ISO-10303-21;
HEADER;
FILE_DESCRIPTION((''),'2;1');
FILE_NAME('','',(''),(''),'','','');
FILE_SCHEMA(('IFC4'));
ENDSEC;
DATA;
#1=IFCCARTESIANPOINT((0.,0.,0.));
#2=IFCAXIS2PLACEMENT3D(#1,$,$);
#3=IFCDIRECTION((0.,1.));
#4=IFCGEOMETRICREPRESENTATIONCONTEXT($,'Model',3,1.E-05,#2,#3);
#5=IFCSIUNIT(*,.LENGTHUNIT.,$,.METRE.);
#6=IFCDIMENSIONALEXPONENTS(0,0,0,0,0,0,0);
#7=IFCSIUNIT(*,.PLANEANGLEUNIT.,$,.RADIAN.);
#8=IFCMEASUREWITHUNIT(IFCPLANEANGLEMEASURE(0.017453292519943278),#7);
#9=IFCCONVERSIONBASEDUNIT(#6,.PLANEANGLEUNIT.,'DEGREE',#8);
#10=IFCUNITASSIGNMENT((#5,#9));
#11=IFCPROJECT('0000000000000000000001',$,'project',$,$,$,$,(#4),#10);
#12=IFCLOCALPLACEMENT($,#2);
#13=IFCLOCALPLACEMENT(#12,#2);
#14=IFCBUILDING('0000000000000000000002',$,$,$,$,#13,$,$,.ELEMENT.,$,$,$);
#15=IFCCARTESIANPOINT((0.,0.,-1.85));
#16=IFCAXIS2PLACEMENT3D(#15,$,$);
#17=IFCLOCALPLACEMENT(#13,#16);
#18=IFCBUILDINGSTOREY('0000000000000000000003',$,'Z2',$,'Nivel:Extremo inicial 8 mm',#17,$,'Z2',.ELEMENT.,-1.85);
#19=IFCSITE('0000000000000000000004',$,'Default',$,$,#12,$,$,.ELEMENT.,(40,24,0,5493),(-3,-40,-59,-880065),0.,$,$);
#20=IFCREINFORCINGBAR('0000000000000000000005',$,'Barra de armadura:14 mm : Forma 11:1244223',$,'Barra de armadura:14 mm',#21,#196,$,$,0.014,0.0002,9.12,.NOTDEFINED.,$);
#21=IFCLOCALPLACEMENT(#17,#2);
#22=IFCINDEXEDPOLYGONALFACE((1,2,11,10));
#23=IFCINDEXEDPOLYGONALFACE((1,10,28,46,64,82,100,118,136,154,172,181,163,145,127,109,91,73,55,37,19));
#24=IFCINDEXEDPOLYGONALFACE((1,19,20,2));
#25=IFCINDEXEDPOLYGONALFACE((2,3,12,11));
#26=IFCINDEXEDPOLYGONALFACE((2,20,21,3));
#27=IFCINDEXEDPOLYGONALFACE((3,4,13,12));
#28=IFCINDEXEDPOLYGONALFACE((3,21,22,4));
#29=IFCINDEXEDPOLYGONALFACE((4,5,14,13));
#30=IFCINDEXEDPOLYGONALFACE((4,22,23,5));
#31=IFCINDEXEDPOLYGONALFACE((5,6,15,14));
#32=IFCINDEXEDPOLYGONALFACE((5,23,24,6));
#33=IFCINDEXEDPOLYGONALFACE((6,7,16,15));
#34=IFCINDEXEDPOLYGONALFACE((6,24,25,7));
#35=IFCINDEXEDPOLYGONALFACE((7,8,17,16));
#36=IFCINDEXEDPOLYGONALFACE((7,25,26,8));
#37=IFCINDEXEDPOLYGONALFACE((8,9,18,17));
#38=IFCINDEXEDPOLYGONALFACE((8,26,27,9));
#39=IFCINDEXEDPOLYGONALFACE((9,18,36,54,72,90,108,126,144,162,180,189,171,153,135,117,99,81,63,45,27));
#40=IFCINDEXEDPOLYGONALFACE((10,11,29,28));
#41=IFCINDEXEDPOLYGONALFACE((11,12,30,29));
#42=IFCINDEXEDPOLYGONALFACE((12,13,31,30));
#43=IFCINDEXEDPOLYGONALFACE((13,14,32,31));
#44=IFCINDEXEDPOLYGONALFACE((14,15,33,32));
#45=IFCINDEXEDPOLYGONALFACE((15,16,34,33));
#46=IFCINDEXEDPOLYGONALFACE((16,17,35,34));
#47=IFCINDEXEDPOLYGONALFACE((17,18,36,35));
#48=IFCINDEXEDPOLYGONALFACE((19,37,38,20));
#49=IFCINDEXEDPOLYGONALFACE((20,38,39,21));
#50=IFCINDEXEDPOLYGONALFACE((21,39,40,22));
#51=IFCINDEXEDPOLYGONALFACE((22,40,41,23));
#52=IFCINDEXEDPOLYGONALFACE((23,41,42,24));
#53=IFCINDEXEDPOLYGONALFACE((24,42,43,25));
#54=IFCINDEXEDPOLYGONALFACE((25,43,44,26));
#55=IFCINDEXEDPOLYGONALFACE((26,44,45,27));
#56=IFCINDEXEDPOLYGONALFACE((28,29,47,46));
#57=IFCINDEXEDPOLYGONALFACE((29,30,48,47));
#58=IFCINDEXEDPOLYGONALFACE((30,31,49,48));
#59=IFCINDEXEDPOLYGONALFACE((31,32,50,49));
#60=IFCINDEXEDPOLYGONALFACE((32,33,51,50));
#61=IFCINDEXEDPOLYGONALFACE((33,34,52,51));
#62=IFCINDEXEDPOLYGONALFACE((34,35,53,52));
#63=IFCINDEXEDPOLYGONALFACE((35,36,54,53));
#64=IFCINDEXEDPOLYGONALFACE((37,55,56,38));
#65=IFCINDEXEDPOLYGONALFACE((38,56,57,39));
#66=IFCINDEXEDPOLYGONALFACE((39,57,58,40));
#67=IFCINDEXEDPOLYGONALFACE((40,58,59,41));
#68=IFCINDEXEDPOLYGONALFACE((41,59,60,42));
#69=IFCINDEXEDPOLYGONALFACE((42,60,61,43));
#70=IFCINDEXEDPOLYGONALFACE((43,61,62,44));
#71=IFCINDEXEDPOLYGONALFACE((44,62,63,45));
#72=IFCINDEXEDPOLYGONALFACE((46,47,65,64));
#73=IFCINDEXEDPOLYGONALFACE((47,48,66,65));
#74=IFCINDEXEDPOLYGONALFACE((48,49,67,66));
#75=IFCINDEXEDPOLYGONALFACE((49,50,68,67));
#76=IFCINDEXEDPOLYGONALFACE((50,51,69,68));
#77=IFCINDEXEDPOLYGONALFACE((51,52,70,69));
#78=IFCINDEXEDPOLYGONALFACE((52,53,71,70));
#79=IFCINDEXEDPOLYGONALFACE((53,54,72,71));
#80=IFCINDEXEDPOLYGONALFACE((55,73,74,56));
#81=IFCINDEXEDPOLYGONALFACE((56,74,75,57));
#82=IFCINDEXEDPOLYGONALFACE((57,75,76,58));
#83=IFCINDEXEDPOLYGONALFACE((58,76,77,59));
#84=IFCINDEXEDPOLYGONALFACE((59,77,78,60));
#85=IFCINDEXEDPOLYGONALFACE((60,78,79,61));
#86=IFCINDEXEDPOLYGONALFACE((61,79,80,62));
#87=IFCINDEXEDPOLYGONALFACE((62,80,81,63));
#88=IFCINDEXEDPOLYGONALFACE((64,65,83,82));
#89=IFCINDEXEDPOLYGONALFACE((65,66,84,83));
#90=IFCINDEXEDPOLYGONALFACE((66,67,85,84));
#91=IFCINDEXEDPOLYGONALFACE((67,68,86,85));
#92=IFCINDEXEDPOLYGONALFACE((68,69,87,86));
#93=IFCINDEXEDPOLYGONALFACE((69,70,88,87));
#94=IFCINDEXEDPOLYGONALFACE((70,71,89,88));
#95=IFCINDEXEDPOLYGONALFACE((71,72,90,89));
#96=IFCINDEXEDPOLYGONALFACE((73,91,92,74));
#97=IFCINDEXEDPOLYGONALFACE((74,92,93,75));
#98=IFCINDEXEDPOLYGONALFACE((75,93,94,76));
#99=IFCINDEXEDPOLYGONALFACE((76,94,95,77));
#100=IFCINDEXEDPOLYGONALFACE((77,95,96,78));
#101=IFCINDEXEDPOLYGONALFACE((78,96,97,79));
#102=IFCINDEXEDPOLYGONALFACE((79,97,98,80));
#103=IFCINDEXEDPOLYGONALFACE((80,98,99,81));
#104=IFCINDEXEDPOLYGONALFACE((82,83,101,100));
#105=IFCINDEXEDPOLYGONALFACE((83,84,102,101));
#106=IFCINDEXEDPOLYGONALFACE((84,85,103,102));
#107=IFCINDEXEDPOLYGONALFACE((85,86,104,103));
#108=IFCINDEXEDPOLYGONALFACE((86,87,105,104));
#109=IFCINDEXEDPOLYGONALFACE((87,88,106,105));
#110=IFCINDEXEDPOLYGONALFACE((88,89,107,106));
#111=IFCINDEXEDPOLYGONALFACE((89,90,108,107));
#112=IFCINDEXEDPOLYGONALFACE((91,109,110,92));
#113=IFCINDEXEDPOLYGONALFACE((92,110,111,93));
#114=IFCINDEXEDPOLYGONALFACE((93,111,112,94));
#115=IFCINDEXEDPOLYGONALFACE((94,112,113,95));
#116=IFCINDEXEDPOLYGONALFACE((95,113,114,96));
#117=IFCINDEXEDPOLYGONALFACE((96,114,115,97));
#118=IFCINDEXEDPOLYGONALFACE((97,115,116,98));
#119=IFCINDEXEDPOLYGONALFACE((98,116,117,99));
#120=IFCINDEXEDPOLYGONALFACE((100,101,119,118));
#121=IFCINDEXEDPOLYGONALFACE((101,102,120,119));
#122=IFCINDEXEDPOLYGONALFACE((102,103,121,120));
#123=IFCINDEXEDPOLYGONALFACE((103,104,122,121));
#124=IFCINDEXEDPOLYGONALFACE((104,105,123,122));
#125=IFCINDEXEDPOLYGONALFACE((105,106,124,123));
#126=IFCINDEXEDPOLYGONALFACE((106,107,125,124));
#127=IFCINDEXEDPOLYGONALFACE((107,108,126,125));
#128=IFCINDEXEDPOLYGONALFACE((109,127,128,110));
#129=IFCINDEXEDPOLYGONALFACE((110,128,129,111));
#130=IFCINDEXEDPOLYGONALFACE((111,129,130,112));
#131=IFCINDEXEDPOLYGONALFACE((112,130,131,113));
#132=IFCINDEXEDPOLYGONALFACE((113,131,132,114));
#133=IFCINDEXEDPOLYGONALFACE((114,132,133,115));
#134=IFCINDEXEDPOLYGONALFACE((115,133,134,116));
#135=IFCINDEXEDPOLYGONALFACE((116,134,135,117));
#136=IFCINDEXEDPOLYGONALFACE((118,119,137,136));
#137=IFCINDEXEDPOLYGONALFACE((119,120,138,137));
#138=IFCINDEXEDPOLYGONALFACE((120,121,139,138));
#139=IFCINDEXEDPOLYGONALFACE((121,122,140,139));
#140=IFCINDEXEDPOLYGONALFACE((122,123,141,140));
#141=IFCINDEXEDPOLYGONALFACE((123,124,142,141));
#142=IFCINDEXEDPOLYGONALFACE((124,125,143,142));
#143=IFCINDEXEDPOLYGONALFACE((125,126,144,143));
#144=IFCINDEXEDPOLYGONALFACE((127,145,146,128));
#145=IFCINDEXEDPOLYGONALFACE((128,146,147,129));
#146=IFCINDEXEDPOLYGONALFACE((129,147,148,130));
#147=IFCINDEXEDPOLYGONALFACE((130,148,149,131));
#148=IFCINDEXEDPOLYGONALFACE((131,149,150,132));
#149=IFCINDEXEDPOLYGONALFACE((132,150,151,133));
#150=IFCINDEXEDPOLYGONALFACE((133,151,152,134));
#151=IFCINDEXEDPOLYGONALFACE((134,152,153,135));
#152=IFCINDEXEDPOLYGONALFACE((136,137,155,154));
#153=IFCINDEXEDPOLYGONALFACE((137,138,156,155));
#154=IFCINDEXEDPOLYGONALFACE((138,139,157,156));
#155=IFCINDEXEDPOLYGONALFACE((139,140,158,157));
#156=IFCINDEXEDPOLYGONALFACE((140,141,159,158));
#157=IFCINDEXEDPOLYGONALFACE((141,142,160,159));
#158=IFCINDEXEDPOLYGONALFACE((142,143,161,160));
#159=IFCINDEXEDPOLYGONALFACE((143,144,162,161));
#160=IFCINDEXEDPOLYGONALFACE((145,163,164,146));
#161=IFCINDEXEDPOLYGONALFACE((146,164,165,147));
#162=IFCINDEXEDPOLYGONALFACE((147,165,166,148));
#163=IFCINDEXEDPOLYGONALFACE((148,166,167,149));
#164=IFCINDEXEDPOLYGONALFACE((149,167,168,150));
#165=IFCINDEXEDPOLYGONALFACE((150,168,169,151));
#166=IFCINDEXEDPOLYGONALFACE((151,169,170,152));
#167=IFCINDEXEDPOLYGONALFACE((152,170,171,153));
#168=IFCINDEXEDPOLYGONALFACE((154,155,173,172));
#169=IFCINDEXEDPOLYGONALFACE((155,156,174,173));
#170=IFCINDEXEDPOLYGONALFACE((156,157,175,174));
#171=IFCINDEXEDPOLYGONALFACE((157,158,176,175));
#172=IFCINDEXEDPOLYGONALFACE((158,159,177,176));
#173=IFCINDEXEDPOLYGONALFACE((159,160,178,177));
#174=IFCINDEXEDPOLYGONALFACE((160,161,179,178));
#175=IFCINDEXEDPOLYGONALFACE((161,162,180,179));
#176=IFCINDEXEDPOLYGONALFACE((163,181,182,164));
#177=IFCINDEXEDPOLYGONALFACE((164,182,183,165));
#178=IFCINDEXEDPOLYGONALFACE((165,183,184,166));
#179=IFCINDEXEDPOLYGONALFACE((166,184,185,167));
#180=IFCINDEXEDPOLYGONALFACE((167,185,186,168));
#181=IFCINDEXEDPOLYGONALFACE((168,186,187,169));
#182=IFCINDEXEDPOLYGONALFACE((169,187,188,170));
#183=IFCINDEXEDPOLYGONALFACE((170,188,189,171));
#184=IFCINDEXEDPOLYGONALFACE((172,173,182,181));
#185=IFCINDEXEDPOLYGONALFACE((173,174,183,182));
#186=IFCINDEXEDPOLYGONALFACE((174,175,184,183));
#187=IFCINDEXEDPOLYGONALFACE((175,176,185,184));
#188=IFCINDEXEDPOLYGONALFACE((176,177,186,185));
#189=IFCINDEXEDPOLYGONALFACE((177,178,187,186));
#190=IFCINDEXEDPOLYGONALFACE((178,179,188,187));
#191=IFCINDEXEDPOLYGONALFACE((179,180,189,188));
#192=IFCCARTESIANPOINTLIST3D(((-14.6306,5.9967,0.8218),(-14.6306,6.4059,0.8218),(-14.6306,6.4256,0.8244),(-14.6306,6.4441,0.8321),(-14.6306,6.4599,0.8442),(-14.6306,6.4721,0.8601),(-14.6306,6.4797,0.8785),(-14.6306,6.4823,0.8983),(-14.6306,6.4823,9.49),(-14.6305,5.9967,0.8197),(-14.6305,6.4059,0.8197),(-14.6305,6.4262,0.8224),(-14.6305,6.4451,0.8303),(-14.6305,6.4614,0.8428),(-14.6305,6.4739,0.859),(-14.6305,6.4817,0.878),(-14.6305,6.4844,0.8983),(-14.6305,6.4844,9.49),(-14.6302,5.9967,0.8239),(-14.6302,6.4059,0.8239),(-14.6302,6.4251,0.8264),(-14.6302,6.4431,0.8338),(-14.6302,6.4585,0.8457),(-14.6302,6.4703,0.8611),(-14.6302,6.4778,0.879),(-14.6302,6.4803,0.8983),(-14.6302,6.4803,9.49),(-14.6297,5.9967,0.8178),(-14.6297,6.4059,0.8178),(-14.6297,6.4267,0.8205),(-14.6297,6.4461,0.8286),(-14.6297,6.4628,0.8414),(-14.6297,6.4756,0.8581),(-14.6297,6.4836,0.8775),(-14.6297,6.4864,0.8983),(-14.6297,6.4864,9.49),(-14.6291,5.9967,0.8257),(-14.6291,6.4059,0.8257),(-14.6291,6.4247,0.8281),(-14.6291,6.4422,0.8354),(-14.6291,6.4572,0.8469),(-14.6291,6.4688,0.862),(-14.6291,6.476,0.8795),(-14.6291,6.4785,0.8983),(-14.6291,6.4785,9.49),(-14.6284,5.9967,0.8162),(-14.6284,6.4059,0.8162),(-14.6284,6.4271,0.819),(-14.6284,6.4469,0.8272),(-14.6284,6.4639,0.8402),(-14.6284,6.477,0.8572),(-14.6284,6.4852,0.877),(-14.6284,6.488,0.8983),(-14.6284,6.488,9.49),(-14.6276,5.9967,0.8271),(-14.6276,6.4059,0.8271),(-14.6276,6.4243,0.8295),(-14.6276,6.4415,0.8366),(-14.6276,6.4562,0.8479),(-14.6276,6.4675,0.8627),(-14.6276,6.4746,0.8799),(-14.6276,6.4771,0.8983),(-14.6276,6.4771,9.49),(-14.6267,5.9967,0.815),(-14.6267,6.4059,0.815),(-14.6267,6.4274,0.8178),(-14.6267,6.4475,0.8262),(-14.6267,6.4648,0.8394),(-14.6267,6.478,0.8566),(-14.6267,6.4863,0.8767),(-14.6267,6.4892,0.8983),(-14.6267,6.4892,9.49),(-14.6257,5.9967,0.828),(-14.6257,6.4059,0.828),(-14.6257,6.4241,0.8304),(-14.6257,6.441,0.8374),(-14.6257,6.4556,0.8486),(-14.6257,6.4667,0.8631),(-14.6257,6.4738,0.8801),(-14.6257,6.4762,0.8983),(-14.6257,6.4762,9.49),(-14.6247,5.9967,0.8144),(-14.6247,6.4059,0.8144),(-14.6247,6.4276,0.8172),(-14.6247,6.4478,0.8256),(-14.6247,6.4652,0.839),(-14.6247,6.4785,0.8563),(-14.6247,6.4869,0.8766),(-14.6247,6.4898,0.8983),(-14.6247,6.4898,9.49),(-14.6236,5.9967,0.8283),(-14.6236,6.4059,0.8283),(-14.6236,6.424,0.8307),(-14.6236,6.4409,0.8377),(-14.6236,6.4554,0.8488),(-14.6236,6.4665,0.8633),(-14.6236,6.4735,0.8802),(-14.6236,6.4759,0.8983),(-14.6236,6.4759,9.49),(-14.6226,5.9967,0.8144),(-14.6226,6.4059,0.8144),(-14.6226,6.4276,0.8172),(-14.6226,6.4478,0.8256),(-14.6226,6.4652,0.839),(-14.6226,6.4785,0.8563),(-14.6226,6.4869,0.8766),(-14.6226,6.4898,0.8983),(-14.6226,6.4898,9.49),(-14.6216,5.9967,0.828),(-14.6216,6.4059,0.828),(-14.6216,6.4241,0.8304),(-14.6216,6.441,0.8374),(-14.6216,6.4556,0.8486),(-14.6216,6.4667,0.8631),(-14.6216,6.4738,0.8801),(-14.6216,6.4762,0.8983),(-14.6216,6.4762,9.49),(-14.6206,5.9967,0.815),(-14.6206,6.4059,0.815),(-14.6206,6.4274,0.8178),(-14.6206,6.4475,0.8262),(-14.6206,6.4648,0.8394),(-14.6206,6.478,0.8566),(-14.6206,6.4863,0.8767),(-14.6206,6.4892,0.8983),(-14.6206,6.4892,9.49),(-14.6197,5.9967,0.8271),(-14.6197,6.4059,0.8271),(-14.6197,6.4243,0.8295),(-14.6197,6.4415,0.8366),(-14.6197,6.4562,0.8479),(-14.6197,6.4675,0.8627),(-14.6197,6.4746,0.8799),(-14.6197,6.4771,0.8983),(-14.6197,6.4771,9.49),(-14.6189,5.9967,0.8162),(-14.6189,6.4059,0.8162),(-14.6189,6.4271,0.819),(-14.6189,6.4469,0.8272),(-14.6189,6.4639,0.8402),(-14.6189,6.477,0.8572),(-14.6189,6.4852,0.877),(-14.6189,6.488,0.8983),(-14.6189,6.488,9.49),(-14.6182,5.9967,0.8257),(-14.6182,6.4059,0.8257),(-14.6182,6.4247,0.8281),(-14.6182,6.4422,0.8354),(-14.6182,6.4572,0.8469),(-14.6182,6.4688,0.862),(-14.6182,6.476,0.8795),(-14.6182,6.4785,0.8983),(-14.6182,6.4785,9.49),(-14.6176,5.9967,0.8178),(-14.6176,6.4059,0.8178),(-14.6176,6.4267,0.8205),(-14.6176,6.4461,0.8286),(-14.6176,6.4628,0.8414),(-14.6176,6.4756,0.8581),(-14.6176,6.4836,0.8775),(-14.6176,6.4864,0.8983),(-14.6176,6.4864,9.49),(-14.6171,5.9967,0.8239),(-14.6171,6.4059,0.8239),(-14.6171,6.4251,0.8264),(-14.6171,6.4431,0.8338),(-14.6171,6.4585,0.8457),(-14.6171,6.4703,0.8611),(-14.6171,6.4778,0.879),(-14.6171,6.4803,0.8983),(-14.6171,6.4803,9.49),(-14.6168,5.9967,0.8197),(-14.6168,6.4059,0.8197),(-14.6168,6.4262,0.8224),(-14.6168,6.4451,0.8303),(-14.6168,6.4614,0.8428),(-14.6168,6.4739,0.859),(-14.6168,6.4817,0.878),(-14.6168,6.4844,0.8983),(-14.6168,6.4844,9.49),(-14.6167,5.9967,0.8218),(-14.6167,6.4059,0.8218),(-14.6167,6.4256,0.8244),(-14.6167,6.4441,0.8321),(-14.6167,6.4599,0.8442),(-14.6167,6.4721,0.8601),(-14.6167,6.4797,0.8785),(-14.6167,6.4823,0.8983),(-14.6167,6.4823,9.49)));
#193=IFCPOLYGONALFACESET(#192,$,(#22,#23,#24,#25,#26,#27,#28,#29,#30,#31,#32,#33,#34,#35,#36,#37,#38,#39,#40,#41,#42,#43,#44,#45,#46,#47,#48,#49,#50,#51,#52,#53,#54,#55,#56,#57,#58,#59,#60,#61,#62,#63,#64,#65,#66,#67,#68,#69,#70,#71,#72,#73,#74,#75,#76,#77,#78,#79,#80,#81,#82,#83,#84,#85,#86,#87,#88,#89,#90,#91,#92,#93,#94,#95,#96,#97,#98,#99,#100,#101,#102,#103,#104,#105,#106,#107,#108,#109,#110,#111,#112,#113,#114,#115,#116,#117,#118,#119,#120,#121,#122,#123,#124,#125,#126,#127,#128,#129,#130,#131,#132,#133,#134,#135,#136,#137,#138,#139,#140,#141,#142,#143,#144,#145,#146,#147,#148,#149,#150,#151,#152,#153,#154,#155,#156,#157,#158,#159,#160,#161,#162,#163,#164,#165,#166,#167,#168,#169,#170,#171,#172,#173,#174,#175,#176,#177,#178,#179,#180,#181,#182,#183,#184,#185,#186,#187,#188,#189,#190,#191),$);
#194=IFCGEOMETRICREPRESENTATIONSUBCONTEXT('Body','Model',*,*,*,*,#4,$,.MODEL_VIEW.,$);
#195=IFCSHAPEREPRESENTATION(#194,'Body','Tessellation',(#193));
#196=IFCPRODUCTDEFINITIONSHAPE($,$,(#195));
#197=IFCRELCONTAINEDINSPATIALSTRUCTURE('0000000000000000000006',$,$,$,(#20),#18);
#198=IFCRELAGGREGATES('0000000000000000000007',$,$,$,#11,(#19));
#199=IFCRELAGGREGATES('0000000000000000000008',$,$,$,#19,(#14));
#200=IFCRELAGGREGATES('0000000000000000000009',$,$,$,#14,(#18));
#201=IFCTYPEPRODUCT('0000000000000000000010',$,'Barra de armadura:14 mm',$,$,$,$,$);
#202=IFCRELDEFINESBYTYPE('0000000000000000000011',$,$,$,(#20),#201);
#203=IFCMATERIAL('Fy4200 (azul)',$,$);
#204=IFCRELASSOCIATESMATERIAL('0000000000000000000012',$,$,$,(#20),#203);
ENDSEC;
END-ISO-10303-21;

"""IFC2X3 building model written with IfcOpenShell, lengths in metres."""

from ifc_helpers import new_model, entity, si_unit, converted_unit, direction, frame, origin, place, context, subcontext, project, spatial, material, type_object, element, save


model = new_model("IFC2X3")

# Units and contexts
model_context = context("Model", 3, precision=1e-05, world=origin(), true_north=direction((0.0, 1.0)))
body_context = subcontext(model_context, "Body", "Model", "MODEL_VIEW")
ifc_project = project(units=[si_unit("LENGTHUNIT", "METRE"), converted_unit("PLANEANGLEUNIT", "DEGREE", entity("IfcPlaneAngleMeasure", 0.017453292519943278), si_unit("PLANEANGLEUNIT", "RADIAN"), dimensions=[0, 0, 0, 0, 0, 0, 0])], contexts=[model_context])

# Site, building, storey
site_placement = place(None, origin())
site = spatial("IfcSite", under=ifc_project, at=site_placement, Name="Default", CompositionType="ELEMENT", RefLatitude=(40, 24, 0, 5493), RefLongitude=(-3, -40, -59, -880065), RefElevation=0.0)
building_placement = place(site_placement, origin())
building = spatial("IfcBuilding", under=site, at=building_placement, CompositionType="ELEMENT")
storey_placement = place(building_placement, frame((0.0, 0.0, -1.85)))
storey = spatial("IfcBuildingStorey", under=building, at=storey_placement, Name="Z2", ObjectType="Nivel:Extremo inicial 8 mm", LongName="Z2", CompositionType="ELEMENT", Elevation=-1.85)

# Reinforcing bar
ifc_material_1 = material(Name="Fy4200 (azul)")
type_product_1 = type_object("IfcTypeProduct", Name="Barra de armadura:14 mm")
reinforcing_bar_1_placement = place(storey_placement, origin())
element("IfcReinforcingBar", 1, at=reinforcing_bar_1_placement, inside=storey, type_object=type_product_1, material=ifc_material_1, Name="Barra de armadura:14 mm : Forma 11:1244223", ObjectType="Barra de armadura:14 mm", BarLength=9.12, BarRole="NOTDEFINED", CrossSectionArea=0.0002, NominalDiameter=0.014, context=body_context, shape_type="AdvancedSweptSolid", body=[
    entity("IfcSweptDiskSolid", entity("IfcCompositeCurve", [entity("IfcCompositeCurveSegment", "CONTINUOUS", True, entity("IfcPolyline", [entity("IfcCartesianPoint", [-14.6236, 6.4829, 9.49]), entity("IfcCartesianPoint", [-14.6236, 6.4829, 0.8983])])), entity("IfcCompositeCurveSegment", "CONTINUOUS", True, entity("IfcTrimmedCurve", entity("IfcCircle", entity("IfcAxis2Placement3D", entity("IfcCartesianPoint", [-14.6236, 6.4059, 0.8983]), entity("IfcDirection", [-1.0, 0.0, 0.0]), entity("IfcDirection", [0.0, 0.0, -1.0])), 0.077), [entity("IfcParameterValue", 270.0)], [entity("IfcParameterValue", 360.0)], True, "PARAMETER")), entity("IfcCompositeCurveSegment", "CONTINUOUS", True, entity("IfcPolyline", [entity("IfcCartesianPoint", [-14.6236, 6.4059, 0.8213]), entity("IfcCartesianPoint", [-14.6236, 5.9967, 0.8213])]))], False), 0.007, None, 0.0, 92.0),
])

save(model, "model.ifc")
